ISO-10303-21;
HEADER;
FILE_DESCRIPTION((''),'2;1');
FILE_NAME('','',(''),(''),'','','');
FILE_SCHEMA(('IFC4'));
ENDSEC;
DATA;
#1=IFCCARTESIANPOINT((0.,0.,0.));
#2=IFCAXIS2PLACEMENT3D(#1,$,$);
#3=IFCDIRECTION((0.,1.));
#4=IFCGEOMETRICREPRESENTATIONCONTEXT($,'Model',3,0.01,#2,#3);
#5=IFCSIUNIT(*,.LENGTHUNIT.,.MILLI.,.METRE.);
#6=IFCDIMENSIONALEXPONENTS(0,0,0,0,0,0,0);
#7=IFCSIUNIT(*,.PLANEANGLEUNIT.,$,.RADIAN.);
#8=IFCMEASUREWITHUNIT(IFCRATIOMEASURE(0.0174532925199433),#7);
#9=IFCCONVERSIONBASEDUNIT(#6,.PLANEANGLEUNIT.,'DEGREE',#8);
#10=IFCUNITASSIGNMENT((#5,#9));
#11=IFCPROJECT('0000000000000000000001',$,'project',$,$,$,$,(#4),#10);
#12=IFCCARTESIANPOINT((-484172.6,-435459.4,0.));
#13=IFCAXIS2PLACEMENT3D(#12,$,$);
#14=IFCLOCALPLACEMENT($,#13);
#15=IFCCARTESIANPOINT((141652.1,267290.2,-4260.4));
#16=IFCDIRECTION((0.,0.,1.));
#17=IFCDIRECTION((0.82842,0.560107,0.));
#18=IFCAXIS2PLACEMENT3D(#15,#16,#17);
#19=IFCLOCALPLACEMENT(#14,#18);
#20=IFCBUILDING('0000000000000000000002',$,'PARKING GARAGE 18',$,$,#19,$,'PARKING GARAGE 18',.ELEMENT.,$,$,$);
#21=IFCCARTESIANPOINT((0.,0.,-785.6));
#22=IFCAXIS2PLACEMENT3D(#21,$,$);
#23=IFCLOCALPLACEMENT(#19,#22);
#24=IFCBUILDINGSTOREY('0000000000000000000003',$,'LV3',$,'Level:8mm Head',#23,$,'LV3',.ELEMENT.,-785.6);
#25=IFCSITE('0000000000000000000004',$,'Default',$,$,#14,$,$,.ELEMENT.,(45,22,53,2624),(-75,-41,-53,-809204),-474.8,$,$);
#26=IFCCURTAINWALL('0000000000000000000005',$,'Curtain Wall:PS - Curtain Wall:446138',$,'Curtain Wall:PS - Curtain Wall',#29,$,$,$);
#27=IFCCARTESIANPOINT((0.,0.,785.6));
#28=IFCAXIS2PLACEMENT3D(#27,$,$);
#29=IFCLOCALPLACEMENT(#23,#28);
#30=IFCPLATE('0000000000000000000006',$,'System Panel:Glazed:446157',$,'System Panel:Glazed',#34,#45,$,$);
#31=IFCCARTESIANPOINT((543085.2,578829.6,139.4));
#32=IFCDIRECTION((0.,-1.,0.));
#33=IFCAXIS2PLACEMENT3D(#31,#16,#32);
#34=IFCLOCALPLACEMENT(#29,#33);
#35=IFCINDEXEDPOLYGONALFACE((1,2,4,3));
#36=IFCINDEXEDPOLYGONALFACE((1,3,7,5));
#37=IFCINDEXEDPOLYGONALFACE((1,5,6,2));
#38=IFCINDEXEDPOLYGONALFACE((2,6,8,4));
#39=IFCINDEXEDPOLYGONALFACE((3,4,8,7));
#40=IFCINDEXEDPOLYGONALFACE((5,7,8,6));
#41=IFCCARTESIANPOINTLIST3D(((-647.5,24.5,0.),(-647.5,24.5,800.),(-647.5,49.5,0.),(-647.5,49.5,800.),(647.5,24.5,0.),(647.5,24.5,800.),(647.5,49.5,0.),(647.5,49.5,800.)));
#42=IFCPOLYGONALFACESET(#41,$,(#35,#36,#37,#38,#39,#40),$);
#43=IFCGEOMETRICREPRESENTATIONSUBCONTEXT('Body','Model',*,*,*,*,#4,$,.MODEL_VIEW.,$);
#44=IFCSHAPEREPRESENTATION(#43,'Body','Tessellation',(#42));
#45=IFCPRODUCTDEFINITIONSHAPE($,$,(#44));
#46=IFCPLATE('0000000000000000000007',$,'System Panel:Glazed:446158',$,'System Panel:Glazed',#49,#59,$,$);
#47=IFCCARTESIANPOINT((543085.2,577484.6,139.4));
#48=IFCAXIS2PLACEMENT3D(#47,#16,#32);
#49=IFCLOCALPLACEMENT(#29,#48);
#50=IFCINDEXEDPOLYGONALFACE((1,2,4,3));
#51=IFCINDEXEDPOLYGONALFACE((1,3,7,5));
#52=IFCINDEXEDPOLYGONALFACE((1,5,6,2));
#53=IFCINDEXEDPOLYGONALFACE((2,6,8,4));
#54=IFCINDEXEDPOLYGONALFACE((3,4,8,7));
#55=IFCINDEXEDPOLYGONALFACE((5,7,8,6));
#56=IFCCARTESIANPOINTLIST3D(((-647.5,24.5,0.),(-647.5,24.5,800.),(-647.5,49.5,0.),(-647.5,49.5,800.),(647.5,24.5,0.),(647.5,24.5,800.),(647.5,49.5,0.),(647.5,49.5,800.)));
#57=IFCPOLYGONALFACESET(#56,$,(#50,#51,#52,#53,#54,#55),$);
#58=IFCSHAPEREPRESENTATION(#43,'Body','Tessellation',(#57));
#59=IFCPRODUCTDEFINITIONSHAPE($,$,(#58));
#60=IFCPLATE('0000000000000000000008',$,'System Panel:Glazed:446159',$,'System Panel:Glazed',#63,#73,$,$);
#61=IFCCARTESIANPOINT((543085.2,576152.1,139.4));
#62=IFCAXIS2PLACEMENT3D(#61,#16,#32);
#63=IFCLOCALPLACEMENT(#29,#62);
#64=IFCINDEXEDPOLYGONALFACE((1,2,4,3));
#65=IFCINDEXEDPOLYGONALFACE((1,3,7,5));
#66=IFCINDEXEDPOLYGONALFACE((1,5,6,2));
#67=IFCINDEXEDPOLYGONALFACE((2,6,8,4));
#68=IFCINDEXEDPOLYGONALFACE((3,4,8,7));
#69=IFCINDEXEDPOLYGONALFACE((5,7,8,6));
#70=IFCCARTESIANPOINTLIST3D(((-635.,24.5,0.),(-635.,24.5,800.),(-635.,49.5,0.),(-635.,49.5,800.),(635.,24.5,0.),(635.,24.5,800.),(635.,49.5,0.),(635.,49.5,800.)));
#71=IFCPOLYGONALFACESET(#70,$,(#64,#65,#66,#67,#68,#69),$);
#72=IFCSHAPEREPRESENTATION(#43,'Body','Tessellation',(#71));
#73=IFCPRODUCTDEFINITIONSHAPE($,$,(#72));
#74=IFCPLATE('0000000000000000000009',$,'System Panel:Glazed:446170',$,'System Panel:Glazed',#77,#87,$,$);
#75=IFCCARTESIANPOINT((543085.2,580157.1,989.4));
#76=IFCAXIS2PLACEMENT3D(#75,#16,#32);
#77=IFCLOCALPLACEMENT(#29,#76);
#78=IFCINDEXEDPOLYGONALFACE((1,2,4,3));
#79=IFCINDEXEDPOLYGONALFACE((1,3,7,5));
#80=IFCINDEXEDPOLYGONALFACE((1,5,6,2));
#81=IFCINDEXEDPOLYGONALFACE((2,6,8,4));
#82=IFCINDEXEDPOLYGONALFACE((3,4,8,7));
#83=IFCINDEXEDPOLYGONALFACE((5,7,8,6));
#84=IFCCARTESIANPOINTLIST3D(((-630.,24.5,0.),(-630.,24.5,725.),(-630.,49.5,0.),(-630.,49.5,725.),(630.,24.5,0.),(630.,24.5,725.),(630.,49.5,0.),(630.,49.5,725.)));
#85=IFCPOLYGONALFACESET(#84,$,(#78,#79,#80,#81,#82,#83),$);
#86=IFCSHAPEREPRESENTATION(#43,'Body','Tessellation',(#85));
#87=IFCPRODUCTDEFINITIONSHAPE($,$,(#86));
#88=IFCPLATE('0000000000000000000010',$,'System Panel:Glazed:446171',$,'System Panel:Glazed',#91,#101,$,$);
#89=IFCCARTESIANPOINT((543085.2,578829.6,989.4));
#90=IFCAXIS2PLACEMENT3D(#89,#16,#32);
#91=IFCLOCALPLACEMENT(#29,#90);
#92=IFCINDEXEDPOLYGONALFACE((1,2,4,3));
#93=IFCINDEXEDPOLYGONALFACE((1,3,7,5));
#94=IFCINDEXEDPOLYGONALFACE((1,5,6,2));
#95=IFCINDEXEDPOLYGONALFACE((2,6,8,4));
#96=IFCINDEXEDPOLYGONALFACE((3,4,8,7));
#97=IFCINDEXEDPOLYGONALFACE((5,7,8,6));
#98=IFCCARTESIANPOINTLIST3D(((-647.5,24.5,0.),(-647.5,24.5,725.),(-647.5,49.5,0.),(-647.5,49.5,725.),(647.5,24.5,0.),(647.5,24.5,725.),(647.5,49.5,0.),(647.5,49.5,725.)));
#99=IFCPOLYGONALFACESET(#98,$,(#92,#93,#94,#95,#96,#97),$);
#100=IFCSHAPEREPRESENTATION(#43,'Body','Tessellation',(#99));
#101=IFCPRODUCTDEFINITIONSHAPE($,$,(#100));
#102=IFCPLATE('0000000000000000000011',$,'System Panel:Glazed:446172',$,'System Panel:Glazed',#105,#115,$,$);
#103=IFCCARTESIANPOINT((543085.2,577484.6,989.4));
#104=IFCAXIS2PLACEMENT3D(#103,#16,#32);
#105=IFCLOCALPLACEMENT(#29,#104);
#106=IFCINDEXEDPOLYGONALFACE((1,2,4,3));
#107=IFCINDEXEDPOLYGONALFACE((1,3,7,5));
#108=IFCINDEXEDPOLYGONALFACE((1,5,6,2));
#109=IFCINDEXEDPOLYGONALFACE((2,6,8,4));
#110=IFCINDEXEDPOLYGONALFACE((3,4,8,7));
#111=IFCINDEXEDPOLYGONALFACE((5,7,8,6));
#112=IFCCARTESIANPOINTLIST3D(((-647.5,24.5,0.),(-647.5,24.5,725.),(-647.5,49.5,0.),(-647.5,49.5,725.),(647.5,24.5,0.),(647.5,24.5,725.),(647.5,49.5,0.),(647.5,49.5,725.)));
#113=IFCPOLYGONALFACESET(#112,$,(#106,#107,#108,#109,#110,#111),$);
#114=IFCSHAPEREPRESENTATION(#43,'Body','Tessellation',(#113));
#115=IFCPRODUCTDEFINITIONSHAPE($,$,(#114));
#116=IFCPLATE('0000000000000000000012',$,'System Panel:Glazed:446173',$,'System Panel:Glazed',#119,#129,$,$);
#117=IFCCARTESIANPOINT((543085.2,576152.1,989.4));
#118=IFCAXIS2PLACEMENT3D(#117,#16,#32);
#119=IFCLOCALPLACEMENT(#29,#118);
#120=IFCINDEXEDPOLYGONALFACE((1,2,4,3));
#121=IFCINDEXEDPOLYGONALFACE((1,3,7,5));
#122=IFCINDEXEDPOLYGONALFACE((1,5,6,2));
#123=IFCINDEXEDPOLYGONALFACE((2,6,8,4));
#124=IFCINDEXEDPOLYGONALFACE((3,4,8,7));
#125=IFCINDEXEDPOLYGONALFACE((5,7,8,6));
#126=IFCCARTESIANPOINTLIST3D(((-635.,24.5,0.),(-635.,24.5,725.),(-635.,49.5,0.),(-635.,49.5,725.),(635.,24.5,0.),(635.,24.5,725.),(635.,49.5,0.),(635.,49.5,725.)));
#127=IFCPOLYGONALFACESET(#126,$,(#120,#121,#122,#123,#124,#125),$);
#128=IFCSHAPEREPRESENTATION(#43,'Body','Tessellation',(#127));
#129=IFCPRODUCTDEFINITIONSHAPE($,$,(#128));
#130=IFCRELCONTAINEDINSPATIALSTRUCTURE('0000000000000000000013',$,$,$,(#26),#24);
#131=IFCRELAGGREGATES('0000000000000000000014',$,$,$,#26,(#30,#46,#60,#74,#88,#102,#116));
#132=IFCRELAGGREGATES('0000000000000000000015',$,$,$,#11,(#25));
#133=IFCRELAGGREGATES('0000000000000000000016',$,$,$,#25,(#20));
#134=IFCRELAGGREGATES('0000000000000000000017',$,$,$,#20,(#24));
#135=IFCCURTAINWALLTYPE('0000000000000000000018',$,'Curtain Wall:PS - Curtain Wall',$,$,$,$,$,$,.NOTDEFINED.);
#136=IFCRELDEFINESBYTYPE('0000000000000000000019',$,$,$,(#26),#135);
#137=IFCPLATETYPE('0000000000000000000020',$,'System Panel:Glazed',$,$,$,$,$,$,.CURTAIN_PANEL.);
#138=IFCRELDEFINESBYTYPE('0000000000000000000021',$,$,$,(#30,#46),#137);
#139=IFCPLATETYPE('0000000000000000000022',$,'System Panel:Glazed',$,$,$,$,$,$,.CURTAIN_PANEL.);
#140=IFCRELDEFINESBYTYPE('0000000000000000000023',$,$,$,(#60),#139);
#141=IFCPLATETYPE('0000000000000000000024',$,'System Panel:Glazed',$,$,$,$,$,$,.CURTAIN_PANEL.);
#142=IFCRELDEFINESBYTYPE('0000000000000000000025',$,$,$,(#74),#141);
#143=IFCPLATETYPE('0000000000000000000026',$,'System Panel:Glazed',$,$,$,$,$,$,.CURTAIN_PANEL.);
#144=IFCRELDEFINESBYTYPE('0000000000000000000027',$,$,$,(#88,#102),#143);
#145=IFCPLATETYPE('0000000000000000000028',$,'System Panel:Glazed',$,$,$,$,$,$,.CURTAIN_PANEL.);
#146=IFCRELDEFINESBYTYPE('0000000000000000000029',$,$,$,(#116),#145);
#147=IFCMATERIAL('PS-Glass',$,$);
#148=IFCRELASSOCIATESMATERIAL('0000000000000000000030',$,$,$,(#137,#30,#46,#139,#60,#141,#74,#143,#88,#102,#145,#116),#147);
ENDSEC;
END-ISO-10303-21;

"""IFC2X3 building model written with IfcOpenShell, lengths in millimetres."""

from ifc_helpers import new_model, entity, si_unit, converted_unit, direction, frame, origin, origin_2d_with_axis, place, context, subcontext, project, spatial, rectangle, extrude, source, transform, mapped, material, type_object, type_shapes, element, aggregate, save


model = new_model("IFC2X3")

# Units and contexts
model_context = context("Model", 3, precision=0.01, world=origin(), true_north=direction((0.0, 1.0)))
body_context = subcontext(model_context, "Body", "Model", "MODEL_VIEW")
ifc_project = project(units=[si_unit("LENGTHUNIT", "METRE", prefix="MILLI"), converted_unit("PLANEANGLEUNIT", "DEGREE", entity("IfcRatioMeasure", 0.0174532925199433), si_unit("PLANEANGLEUNIT", "RADIAN"), dimensions=[0, 0, 0, 0, 0, 0, 0])], contexts=[model_context])

# Site, building, storey
site_placement = place(None, frame((-484172.6, -435459.4, 0.0)))
site = spatial("IfcSite", under=ifc_project, at=site_placement, Name="Default", CompositionType="ELEMENT", RefLatitude=(45, 22, 53, 2624), RefLongitude=(-75, -41, -53, -809204), RefElevation=-474.8)
building_placement = place(site_placement, frame((141652.1, 267290.2, -4260.4), z_axis=(0.0, 0.0, 1.0), x_axis=(0.82842, 0.560107, 0.0)))
building = spatial("IfcBuilding", under=site, at=building_placement, Name="PARKING GARAGE 18", LongName="PARKING GARAGE 18", CompositionType="ELEMENT")
storey_placement = place(building_placement, frame((0.0, 0.0, -785.6)))
storey = spatial("IfcBuildingStorey", under=building, at=storey_placement, Name="LV3", ObjectType="Level:8mm Head", LongName="LV3", CompositionType="ELEMENT", Elevation=-785.6)

# Curtain wall, plates
curtain_wall_type = type_object("IfcCurtainWallType", Name="Curtain Wall:PS - Curtain Wall", PredefinedType="NOTDEFINED")
ifc_material_1 = material(Name="PS-Glass")
curtain_wall_1_placement = place(storey_placement, frame((0.0, 0.0, 785.6)))
curtain_wall_1 = element("IfcCurtainWall", 1, at=curtain_wall_1_placement, inside=storey, type_object=curtain_wall_type, Name="Curtain Wall:PS - Curtain Wall:446138", ObjectType="Curtain Wall:PS - Curtain Wall")
plate_type_1 = type_object("IfcPlateType", Name="System Panel:Glazed", PredefinedType="CURTAIN_PANEL", material=ifc_material_1)
shared_shape_1 = source(origin(), body_context, "Body", "SweptSolid", [
    extrude(rectangle(XDim=25.0, YDim=1295.0, at=origin_2d_with_axis()), frame((0.0, 37.0, 0.0), z_axis=(0.0, 0.0, 1.0), x_axis=(0.0, 1.0, 0.0)), (0.0, 0.0, 1.0), 800.0),
])
type_shapes(plate_type_1, [shared_shape_1])
plate_1_placement = place(curtain_wall_1_placement, frame((543085.2, 578829.6, 139.4), z_axis=(0.0, 0.0, 1.0), x_axis=(0.0, -1.0, 0.0)))
plate_1 = element("IfcPlate", 2, at=plate_1_placement, type_object=plate_type_1, material=ifc_material_1, Name="System Panel:Glazed:446157", ObjectType="System Panel:Glazed", context=body_context, shape_type="MappedRepresentation", body=[
    mapped(shared_shape_1, transform((0.0, 0.0, 0.0), scale=1.0)),
])
plate_2_placement = place(curtain_wall_1_placement, frame((543085.2, 577484.6, 139.4), z_axis=(0.0, 0.0, 1.0), x_axis=(0.0, -1.0, 0.0)))
plate_2 = element("IfcPlate", 3, at=plate_2_placement, type_object=plate_type_1, material=ifc_material_1, Name="System Panel:Glazed:446158", ObjectType="System Panel:Glazed", context=body_context, shape_type="MappedRepresentation", body=[
    mapped(shared_shape_1, transform((0.0, 0.0, 0.0), scale=1.0)),
])
plate_type_2 = type_object("IfcPlateType", Name="System Panel:Glazed", PredefinedType="CURTAIN_PANEL", material=ifc_material_1)
shared_shape_2 = source(origin(), body_context, "Body", "SweptSolid", [
    extrude(rectangle(XDim=25.0, YDim=1270.0, at=origin_2d_with_axis()), frame((0.0, 37.0, 0.0), z_axis=(0.0, 0.0, 1.0), x_axis=(0.0, 1.0, 0.0)), (0.0, 0.0, 1.0), 800.0),
])
type_shapes(plate_type_2, [shared_shape_2])
plate_3_placement = place(curtain_wall_1_placement, frame((543085.2, 576152.1, 139.4), z_axis=(0.0, 0.0, 1.0), x_axis=(0.0, -1.0, 0.0)))
plate_3 = element("IfcPlate", 4, at=plate_3_placement, type_object=plate_type_2, material=ifc_material_1, Name="System Panel:Glazed:446159", ObjectType="System Panel:Glazed", context=body_context, shape_type="MappedRepresentation", body=[
    mapped(shared_shape_2, transform((0.0, 0.0, 0.0), scale=1.0)),
])
plate_type_3 = type_object("IfcPlateType", Name="System Panel:Glazed", PredefinedType="CURTAIN_PANEL", material=ifc_material_1)
shared_shape_3 = source(origin(), body_context, "Body", "SweptSolid", [
    extrude(rectangle(XDim=25.0, YDim=1260.1, at=origin_2d_with_axis()), frame((0.0, 37.0, 0.0), z_axis=(0.0, 0.0, 1.0), x_axis=(0.0, 1.0, 0.0)), (0.0, 0.0, 1.0), 725.0),
])
type_shapes(plate_type_3, [shared_shape_3])
plate_4_placement = place(curtain_wall_1_placement, frame((543085.2, 580157.1, 989.4), z_axis=(0.0, 0.0, 1.0), x_axis=(0.0, -1.0, 0.0)))
plate_4 = element("IfcPlate", 5, at=plate_4_placement, type_object=plate_type_3, material=ifc_material_1, Name="System Panel:Glazed:446170", ObjectType="System Panel:Glazed", context=body_context, shape_type="MappedRepresentation", body=[
    mapped(shared_shape_3, transform((0.0, 0.0, 0.0), scale=1.0)),
])
plate_type_4 = type_object("IfcPlateType", Name="System Panel:Glazed", PredefinedType="CURTAIN_PANEL", material=ifc_material_1)
shared_shape_4 = source(origin(), body_context, "Body", "SweptSolid", [
    extrude(rectangle(XDim=25.0, YDim=1295.0, at=origin_2d_with_axis()), frame((0.0, 37.0, 0.0), z_axis=(0.0, 0.0, 1.0), x_axis=(0.0, 1.0, 0.0)), (0.0, 0.0, 1.0), 725.0),
])
type_shapes(plate_type_4, [shared_shape_4])
plate_5_placement = place(curtain_wall_1_placement, frame((543085.2, 578829.6, 989.4), z_axis=(0.0, 0.0, 1.0), x_axis=(0.0, -1.0, 0.0)))
plate_5 = element("IfcPlate", 6, at=plate_5_placement, type_object=plate_type_4, material=ifc_material_1, Name="System Panel:Glazed:446171", ObjectType="System Panel:Glazed", context=body_context, shape_type="MappedRepresentation", body=[
    mapped(shared_shape_4, transform((0.0, 0.0, 0.0), scale=1.0)),
])
plate_6_placement = place(curtain_wall_1_placement, frame((543085.2, 577484.6, 989.4), z_axis=(0.0, 0.0, 1.0), x_axis=(0.0, -1.0, 0.0)))
plate_6 = element("IfcPlate", 7, at=plate_6_placement, type_object=plate_type_4, material=ifc_material_1, Name="System Panel:Glazed:446172", ObjectType="System Panel:Glazed", context=body_context, shape_type="MappedRepresentation", body=[
    mapped(shared_shape_4, transform((0.0, 0.0, 0.0), scale=1.0)),
])
plate_type_5 = type_object("IfcPlateType", Name="System Panel:Glazed", PredefinedType="CURTAIN_PANEL", material=ifc_material_1)
shared_shape_5 = source(origin(), body_context, "Body", "SweptSolid", [
    extrude(rectangle(XDim=25.0, YDim=1270.0, at=origin_2d_with_axis()), frame((0.0, 37.0, 0.0), z_axis=(0.0, 0.0, 1.0), x_axis=(0.0, 1.0, 0.0)), (0.0, 0.0, 1.0), 725.0),
])
type_shapes(plate_type_5, [shared_shape_5])
plate_7_placement = place(curtain_wall_1_placement, frame((543085.2, 576152.1, 989.4), z_axis=(0.0, 0.0, 1.0), x_axis=(0.0, -1.0, 0.0)))
plate_7 = element("IfcPlate", 8, at=plate_7_placement, type_object=plate_type_5, material=ifc_material_1, Name="System Panel:Glazed:446173", ObjectType="System Panel:Glazed", context=body_context, shape_type="MappedRepresentation", body=[
    mapped(shared_shape_5, transform((0.0, 0.0, 0.0), scale=1.0)),
])
aggregate(curtain_wall_1, [plate_1, plate_2, plate_3, plate_4, plate_5, plate_6, plate_7])

save(model, "model.ifc")
